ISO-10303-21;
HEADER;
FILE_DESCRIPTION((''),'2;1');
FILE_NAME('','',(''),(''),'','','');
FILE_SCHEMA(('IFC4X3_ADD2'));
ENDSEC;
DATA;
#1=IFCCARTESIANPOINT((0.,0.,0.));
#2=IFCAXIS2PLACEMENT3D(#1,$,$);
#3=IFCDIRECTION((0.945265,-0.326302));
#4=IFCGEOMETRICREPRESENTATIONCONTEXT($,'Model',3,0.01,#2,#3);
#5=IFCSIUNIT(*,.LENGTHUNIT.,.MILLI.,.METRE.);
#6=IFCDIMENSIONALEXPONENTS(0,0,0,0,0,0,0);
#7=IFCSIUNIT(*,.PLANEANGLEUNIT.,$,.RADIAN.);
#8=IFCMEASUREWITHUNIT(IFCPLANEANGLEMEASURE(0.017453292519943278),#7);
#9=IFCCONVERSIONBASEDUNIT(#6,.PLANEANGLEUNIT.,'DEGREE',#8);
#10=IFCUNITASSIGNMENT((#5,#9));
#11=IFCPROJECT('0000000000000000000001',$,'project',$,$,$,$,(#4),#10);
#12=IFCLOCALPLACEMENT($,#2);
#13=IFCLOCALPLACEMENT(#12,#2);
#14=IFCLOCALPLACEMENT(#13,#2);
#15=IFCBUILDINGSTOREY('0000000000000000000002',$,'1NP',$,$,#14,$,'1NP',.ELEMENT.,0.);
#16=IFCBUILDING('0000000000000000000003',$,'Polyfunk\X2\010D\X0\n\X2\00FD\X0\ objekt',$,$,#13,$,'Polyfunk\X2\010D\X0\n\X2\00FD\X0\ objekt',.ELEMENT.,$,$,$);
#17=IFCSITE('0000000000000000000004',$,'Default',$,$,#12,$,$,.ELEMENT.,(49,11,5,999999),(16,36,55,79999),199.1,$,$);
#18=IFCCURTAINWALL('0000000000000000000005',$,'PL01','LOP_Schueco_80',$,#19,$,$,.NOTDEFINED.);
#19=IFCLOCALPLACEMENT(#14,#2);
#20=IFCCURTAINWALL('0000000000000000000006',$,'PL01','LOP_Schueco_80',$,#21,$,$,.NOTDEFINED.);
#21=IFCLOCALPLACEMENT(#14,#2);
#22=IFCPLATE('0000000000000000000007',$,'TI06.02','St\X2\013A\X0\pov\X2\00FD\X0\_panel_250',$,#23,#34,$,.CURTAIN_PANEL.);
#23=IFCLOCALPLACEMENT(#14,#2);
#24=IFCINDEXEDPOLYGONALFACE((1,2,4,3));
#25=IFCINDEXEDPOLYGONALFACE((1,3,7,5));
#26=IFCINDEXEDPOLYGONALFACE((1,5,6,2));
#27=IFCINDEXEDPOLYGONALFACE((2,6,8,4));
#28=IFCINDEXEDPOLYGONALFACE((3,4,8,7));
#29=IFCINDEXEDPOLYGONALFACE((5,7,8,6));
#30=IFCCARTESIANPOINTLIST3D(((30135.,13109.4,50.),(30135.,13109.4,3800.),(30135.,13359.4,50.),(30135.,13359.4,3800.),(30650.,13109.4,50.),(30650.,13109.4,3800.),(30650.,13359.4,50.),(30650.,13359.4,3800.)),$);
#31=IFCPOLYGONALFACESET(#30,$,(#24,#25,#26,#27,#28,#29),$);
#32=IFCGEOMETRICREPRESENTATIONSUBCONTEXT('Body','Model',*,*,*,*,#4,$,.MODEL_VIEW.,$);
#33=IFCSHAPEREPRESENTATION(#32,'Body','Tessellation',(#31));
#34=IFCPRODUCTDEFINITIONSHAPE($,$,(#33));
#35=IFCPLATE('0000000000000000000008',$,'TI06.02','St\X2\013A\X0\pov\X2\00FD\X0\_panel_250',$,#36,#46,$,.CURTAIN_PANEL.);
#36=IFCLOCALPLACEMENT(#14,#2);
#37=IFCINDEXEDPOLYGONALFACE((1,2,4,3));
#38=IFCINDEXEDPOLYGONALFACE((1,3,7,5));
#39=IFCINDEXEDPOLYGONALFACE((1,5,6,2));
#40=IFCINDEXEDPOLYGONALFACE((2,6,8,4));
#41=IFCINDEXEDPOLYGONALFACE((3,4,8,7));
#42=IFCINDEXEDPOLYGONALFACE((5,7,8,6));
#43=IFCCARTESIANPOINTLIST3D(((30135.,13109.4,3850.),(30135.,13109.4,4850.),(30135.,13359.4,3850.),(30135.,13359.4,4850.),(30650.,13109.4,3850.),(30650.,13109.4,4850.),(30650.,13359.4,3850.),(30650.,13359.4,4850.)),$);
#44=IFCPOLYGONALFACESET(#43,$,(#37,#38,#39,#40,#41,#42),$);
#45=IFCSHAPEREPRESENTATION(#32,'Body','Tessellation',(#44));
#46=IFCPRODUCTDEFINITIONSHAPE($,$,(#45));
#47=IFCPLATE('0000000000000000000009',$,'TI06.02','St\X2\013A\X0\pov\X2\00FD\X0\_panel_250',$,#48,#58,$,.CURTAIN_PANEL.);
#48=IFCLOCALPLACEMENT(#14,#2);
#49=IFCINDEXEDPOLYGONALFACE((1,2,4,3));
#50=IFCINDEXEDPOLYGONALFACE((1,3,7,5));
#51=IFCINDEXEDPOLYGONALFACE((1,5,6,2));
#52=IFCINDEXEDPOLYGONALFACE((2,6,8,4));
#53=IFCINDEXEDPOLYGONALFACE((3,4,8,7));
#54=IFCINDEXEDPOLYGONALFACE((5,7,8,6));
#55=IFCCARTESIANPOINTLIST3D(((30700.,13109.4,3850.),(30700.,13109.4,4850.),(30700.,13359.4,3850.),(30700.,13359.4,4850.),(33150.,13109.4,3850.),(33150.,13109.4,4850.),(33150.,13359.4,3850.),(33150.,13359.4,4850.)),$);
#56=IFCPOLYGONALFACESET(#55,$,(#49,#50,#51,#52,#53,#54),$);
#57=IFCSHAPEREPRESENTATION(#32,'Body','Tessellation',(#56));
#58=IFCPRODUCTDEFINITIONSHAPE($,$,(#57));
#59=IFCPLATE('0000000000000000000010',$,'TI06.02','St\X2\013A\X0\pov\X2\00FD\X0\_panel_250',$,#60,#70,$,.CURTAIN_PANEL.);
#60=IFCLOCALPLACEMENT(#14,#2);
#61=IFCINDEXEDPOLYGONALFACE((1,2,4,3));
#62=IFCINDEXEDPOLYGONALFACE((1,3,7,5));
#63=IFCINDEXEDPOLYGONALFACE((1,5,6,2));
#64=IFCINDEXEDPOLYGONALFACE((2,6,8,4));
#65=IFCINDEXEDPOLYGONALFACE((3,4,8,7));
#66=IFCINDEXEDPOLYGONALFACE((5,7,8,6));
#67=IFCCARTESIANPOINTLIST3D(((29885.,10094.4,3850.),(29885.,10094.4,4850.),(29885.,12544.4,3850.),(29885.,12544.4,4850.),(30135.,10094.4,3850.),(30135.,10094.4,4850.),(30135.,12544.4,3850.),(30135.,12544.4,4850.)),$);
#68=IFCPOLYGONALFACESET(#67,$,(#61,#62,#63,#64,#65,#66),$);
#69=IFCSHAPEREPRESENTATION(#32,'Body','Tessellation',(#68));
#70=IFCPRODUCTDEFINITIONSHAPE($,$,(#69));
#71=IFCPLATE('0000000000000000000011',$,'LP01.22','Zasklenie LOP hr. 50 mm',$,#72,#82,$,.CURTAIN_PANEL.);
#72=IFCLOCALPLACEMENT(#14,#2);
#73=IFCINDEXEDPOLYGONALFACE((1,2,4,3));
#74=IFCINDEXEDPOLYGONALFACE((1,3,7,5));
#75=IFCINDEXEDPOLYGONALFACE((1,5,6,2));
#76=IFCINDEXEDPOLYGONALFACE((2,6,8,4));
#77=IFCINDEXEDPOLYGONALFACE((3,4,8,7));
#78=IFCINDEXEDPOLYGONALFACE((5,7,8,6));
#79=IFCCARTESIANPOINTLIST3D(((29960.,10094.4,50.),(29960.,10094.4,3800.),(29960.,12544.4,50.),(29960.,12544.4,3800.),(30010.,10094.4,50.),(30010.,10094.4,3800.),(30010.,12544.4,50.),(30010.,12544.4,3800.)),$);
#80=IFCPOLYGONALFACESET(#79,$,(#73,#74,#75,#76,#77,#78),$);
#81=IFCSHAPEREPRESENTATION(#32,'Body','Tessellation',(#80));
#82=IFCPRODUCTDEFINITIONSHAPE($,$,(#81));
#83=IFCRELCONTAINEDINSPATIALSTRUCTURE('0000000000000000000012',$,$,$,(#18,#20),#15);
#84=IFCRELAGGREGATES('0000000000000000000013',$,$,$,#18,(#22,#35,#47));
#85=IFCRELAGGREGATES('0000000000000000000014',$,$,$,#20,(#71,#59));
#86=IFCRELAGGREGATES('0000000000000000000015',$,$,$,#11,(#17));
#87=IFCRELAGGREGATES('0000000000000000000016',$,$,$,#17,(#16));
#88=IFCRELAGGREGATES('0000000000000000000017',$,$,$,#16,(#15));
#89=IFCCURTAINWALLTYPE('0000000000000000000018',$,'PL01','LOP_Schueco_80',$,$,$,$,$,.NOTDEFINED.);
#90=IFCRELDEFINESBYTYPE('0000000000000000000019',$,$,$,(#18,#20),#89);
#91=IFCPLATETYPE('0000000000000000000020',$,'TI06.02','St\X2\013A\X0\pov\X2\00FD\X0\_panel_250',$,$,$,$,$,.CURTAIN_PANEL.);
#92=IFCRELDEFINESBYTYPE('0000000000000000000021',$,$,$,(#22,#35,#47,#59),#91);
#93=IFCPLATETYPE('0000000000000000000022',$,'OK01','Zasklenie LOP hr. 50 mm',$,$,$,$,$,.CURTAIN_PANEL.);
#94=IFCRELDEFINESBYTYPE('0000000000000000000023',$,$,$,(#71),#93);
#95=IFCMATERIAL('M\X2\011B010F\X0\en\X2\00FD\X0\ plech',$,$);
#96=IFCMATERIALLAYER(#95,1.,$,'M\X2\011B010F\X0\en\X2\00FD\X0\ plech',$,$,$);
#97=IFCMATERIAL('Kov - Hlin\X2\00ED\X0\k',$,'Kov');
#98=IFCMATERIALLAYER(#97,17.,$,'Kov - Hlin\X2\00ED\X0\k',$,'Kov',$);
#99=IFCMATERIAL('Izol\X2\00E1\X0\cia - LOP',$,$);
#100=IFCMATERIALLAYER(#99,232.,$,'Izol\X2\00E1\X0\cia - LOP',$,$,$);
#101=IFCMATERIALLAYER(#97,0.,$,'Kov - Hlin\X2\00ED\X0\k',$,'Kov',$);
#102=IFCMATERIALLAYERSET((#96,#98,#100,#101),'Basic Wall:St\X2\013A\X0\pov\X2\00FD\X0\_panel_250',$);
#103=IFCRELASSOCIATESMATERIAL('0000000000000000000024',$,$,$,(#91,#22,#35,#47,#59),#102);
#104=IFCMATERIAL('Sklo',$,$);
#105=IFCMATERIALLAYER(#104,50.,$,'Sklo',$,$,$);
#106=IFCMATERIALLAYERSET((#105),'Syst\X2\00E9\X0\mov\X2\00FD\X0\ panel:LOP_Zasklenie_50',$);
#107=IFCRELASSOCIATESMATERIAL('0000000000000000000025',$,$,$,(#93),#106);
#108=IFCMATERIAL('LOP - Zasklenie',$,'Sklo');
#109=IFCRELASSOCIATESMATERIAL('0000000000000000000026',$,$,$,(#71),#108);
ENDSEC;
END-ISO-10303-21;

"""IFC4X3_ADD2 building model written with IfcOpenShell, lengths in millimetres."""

from ifc_helpers import new_model, entity, si_unit, converted_unit, direction, frame, frame_2d, origin, place, context, subcontext, project, spatial, rectangle, extrude, source, transform, mapped, material, layer, layer_set, layer_usage, type_object, type_shapes, element, aggregate, save


model = new_model("IFC4X3_ADD2")

# Units and contexts
model_context = context("Model", 3, precision=0.01, world=origin(), true_north=direction((0.945265, -0.326302)))
body_context = subcontext(model_context, "Body", "Model", "MODEL_VIEW")
ifc_project = project(units=[si_unit("LENGTHUNIT", "METRE", prefix="MILLI"), converted_unit("PLANEANGLEUNIT", "DEGREE", entity("IfcPlaneAngleMeasure", 0.017453292519943278), si_unit("PLANEANGLEUNIT", "RADIAN"), dimensions=[0, 0, 0, 0, 0, 0, 0])], contexts=[model_context])

# Site, building, storey
site_placement = place(None, origin())
site = spatial("IfcSite", under=ifc_project, at=site_placement, Name="Default", CompositionType="ELEMENT", RefLatitude=(49, 11, 5, 999999), RefLongitude=(16, 36, 55, 79999), RefElevation=199.1)
building_placement = place(site_placement, origin())
building = spatial("IfcBuilding", under=site, at=building_placement, Name="Polyfunkčný objekt", LongName="Polyfunkčný objekt", CompositionType="ELEMENT")
storey_placement = place(building_placement, origin())
storey = spatial("IfcBuildingStorey", under=building, at=storey_placement, Name="1NP", LongName="1NP", CompositionType="ELEMENT", Elevation=0.0)

# Curtain walls
curtain_wall_type = type_object("IfcCurtainWallType", Name="PL01", Description="LOP_Schueco_80", PredefinedType="NOTDEFINED")
curtain_wall_1_placement = place(storey_placement, origin())
curtain_wall_1 = element("IfcCurtainWall", 1, at=curtain_wall_1_placement, inside=storey, type_object=curtain_wall_type, Name="PL01", Description="LOP_Schueco_80", PredefinedType="NOTDEFINED")
curtain_wall_2_placement = place(storey_placement, origin())
curtain_wall_2 = element("IfcCurtainWall", 2, at=curtain_wall_2_placement, inside=storey, type_object=curtain_wall_type, Name="PL01", Description="LOP_Schueco_80", PredefinedType="NOTDEFINED")

# Plates
ifc_material_1 = material(Name="Měďený plech")
ifc_layer_1 = layer(ifc_material_1, 1.0, Name="Měďený plech")
ifc_material_2 = material(Name="Kov - Hliník", Category="Kov")
ifc_layer_2 = layer(ifc_material_2, 17.0, Name="Kov - Hliník", Category="Kov")
ifc_material_3 = material(Name="Izolácia - LOP")
ifc_layer_3 = layer(ifc_material_3, 232.0, Name="Izolácia - LOP")
ifc_layer_4 = layer(ifc_material_2, 0.0, Name="Kov - Hliník", Category="Kov")
ifc_layer_set_1 = layer_set([ifc_layer_1, ifc_layer_2, ifc_layer_3, ifc_layer_4], Name="Basic Wall:Stĺpový_panel_250")
ifc_layer_usage_1 = layer_usage(ifc_layer_set_1, "AXIS2", "NEGATIVE", 125.0)
plate_type_1 = type_object("IfcPlateType", Name="TI06.02", Description="Stĺpový_panel_250", PredefinedType="CURTAIN_PANEL", material=ifc_layer_set_1)
plate_1_placement = place(storey_placement, frame((30135.0, 13234.4, 50.0)))
plate_1 = element("IfcPlate", 3, at=plate_1_placement, type_object=plate_type_1, material=ifc_layer_usage_1, Name="TI06.02", Description="Stĺpový_panel_250", PredefinedType="CURTAIN_PANEL", context=body_context, shape_type="SweptSolid", body=[
    extrude(rectangle(XDim=250.0, YDim=515.0, at=frame_2d((0.0, 0.0), x_axis=(1.0, 0.0))), frame((257.5, 0.0, 0.0), z_axis=(0.0, 0.0, 1.0), x_axis=(0.0, 1.0, 0.0)), (0.0, 0.0, 1.0), 3750.0),
])
ifc_layer_usage_2 = layer_usage(ifc_layer_set_1, "AXIS2", "NEGATIVE", 125.0)
plate_2_placement = place(storey_placement, frame((30135.0, 13234.4, 3850.0)))
plate_2 = element("IfcPlate", 4, at=plate_2_placement, type_object=plate_type_1, material=ifc_layer_usage_2, Name="TI06.02", Description="Stĺpový_panel_250", PredefinedType="CURTAIN_PANEL", context=body_context, shape_type="SweptSolid", body=[
    extrude(rectangle(XDim=250.0, YDim=515.0, at=frame_2d((0.0, 0.0), x_axis=(1.0, 0.0))), frame((257.5, 0.0, 0.0), z_axis=(0.0, 0.0, 1.0), x_axis=(0.0, 1.0, 0.0)), (0.0, 0.0, 1.0), 1000.0),
])
ifc_layer_usage_3 = layer_usage(ifc_layer_set_1, "AXIS2", "NEGATIVE", 125.0)
plate_3_placement = place(storey_placement, frame((30700.0, 13234.4, 3850.0)))
plate_3 = element("IfcPlate", 5, at=plate_3_placement, type_object=plate_type_1, material=ifc_layer_usage_3, Name="TI06.02", Description="Stĺpový_panel_250", PredefinedType="CURTAIN_PANEL", context=body_context, shape_type="SweptSolid", body=[
    extrude(rectangle(XDim=250.0, YDim=2450.0, at=frame_2d((0.0, 0.0), x_axis=(1.0, 0.0))), frame((1225.0, 0.0, 0.0), z_axis=(0.0, 0.0, 1.0), x_axis=(0.0, 1.0, 0.0)), (0.0, 0.0, 1.0), 1000.0),
])
aggregate(curtain_wall_1, [plate_1, plate_2, plate_3])
ifc_layer_usage_4 = layer_usage(ifc_layer_set_1, "AXIS2", "POSITIVE", -125.0)
plate_4_placement = place(storey_placement, frame((30010.0, 12544.4, 3850.0), z_axis=(0.0, 0.0, 1.0), x_axis=(0.0, -1.0, 0.0)))
plate_4 = element("IfcPlate", 6, at=plate_4_placement, type_object=plate_type_1, material=ifc_layer_usage_4, Name="TI06.02", Description="Stĺpový_panel_250", PredefinedType="CURTAIN_PANEL", context=body_context, shape_type="SweptSolid", body=[
    extrude(rectangle(XDim=250.0, YDim=2450.0, at=frame_2d((0.0, 0.0), x_axis=(1.0, 0.0))), frame((1225.0, 0.0, 0.0), z_axis=(0.0, 0.0, 1.0), x_axis=(0.0, 1.0, 0.0)), (0.0, 0.0, 1.0), 1000.0),
])
ifc_material_4 = material(Name="LOP - Zasklenie", Category="Sklo")
ifc_material_5 = material(Name="Sklo")
ifc_layer_5 = layer(ifc_material_5, 50.0, Name="Sklo")
ifc_layer_set_2 = layer_set([ifc_layer_5], Name="Systémový panel:LOP_Zasklenie_50")
plate_type_2 = type_object("IfcPlateType", Name="OK01", Description="Zasklenie LOP hr. 50 mm", PredefinedType="CURTAIN_PANEL", material=ifc_layer_set_2)
shared_shape_1 = source(origin(), body_context, "Body", "SweptSolid", [
    extrude(rectangle(XDim=3750.0, YDim=2450.0, at=frame_2d((-141.7, 0.0), x_axis=(1.0, 0.0))), frame((0.0, -50.0, 2016.7), z_axis=(0.0, 1.0, 0.0), x_axis=(0.0, 0.0, 1.0)), (0.0, 0.0, 1.0), 50.0),
])
type_shapes(plate_type_2, [shared_shape_1])
plate_5_placement = place(curtain_wall_2_placement, frame((30010.0, 11319.4, 50.0), z_axis=(0.0, 0.0, 1.0), x_axis=(0.0, -1.0, 0.0)))
plate_5 = element("IfcPlate", 7, at=plate_5_placement, type_object=plate_type_2, material=ifc_material_4, Name="LP01.22", Description="Zasklenie LOP hr. 50 mm", PredefinedType="CURTAIN_PANEL", context=body_context, shape_type="MappedRepresentation", body=[
    mapped(shared_shape_1, transform((0.0, 0.0, 0.0), scale=1.0)),
])
aggregate(curtain_wall_2, [plate_5, plate_4])

save(model, "model.ifc")
